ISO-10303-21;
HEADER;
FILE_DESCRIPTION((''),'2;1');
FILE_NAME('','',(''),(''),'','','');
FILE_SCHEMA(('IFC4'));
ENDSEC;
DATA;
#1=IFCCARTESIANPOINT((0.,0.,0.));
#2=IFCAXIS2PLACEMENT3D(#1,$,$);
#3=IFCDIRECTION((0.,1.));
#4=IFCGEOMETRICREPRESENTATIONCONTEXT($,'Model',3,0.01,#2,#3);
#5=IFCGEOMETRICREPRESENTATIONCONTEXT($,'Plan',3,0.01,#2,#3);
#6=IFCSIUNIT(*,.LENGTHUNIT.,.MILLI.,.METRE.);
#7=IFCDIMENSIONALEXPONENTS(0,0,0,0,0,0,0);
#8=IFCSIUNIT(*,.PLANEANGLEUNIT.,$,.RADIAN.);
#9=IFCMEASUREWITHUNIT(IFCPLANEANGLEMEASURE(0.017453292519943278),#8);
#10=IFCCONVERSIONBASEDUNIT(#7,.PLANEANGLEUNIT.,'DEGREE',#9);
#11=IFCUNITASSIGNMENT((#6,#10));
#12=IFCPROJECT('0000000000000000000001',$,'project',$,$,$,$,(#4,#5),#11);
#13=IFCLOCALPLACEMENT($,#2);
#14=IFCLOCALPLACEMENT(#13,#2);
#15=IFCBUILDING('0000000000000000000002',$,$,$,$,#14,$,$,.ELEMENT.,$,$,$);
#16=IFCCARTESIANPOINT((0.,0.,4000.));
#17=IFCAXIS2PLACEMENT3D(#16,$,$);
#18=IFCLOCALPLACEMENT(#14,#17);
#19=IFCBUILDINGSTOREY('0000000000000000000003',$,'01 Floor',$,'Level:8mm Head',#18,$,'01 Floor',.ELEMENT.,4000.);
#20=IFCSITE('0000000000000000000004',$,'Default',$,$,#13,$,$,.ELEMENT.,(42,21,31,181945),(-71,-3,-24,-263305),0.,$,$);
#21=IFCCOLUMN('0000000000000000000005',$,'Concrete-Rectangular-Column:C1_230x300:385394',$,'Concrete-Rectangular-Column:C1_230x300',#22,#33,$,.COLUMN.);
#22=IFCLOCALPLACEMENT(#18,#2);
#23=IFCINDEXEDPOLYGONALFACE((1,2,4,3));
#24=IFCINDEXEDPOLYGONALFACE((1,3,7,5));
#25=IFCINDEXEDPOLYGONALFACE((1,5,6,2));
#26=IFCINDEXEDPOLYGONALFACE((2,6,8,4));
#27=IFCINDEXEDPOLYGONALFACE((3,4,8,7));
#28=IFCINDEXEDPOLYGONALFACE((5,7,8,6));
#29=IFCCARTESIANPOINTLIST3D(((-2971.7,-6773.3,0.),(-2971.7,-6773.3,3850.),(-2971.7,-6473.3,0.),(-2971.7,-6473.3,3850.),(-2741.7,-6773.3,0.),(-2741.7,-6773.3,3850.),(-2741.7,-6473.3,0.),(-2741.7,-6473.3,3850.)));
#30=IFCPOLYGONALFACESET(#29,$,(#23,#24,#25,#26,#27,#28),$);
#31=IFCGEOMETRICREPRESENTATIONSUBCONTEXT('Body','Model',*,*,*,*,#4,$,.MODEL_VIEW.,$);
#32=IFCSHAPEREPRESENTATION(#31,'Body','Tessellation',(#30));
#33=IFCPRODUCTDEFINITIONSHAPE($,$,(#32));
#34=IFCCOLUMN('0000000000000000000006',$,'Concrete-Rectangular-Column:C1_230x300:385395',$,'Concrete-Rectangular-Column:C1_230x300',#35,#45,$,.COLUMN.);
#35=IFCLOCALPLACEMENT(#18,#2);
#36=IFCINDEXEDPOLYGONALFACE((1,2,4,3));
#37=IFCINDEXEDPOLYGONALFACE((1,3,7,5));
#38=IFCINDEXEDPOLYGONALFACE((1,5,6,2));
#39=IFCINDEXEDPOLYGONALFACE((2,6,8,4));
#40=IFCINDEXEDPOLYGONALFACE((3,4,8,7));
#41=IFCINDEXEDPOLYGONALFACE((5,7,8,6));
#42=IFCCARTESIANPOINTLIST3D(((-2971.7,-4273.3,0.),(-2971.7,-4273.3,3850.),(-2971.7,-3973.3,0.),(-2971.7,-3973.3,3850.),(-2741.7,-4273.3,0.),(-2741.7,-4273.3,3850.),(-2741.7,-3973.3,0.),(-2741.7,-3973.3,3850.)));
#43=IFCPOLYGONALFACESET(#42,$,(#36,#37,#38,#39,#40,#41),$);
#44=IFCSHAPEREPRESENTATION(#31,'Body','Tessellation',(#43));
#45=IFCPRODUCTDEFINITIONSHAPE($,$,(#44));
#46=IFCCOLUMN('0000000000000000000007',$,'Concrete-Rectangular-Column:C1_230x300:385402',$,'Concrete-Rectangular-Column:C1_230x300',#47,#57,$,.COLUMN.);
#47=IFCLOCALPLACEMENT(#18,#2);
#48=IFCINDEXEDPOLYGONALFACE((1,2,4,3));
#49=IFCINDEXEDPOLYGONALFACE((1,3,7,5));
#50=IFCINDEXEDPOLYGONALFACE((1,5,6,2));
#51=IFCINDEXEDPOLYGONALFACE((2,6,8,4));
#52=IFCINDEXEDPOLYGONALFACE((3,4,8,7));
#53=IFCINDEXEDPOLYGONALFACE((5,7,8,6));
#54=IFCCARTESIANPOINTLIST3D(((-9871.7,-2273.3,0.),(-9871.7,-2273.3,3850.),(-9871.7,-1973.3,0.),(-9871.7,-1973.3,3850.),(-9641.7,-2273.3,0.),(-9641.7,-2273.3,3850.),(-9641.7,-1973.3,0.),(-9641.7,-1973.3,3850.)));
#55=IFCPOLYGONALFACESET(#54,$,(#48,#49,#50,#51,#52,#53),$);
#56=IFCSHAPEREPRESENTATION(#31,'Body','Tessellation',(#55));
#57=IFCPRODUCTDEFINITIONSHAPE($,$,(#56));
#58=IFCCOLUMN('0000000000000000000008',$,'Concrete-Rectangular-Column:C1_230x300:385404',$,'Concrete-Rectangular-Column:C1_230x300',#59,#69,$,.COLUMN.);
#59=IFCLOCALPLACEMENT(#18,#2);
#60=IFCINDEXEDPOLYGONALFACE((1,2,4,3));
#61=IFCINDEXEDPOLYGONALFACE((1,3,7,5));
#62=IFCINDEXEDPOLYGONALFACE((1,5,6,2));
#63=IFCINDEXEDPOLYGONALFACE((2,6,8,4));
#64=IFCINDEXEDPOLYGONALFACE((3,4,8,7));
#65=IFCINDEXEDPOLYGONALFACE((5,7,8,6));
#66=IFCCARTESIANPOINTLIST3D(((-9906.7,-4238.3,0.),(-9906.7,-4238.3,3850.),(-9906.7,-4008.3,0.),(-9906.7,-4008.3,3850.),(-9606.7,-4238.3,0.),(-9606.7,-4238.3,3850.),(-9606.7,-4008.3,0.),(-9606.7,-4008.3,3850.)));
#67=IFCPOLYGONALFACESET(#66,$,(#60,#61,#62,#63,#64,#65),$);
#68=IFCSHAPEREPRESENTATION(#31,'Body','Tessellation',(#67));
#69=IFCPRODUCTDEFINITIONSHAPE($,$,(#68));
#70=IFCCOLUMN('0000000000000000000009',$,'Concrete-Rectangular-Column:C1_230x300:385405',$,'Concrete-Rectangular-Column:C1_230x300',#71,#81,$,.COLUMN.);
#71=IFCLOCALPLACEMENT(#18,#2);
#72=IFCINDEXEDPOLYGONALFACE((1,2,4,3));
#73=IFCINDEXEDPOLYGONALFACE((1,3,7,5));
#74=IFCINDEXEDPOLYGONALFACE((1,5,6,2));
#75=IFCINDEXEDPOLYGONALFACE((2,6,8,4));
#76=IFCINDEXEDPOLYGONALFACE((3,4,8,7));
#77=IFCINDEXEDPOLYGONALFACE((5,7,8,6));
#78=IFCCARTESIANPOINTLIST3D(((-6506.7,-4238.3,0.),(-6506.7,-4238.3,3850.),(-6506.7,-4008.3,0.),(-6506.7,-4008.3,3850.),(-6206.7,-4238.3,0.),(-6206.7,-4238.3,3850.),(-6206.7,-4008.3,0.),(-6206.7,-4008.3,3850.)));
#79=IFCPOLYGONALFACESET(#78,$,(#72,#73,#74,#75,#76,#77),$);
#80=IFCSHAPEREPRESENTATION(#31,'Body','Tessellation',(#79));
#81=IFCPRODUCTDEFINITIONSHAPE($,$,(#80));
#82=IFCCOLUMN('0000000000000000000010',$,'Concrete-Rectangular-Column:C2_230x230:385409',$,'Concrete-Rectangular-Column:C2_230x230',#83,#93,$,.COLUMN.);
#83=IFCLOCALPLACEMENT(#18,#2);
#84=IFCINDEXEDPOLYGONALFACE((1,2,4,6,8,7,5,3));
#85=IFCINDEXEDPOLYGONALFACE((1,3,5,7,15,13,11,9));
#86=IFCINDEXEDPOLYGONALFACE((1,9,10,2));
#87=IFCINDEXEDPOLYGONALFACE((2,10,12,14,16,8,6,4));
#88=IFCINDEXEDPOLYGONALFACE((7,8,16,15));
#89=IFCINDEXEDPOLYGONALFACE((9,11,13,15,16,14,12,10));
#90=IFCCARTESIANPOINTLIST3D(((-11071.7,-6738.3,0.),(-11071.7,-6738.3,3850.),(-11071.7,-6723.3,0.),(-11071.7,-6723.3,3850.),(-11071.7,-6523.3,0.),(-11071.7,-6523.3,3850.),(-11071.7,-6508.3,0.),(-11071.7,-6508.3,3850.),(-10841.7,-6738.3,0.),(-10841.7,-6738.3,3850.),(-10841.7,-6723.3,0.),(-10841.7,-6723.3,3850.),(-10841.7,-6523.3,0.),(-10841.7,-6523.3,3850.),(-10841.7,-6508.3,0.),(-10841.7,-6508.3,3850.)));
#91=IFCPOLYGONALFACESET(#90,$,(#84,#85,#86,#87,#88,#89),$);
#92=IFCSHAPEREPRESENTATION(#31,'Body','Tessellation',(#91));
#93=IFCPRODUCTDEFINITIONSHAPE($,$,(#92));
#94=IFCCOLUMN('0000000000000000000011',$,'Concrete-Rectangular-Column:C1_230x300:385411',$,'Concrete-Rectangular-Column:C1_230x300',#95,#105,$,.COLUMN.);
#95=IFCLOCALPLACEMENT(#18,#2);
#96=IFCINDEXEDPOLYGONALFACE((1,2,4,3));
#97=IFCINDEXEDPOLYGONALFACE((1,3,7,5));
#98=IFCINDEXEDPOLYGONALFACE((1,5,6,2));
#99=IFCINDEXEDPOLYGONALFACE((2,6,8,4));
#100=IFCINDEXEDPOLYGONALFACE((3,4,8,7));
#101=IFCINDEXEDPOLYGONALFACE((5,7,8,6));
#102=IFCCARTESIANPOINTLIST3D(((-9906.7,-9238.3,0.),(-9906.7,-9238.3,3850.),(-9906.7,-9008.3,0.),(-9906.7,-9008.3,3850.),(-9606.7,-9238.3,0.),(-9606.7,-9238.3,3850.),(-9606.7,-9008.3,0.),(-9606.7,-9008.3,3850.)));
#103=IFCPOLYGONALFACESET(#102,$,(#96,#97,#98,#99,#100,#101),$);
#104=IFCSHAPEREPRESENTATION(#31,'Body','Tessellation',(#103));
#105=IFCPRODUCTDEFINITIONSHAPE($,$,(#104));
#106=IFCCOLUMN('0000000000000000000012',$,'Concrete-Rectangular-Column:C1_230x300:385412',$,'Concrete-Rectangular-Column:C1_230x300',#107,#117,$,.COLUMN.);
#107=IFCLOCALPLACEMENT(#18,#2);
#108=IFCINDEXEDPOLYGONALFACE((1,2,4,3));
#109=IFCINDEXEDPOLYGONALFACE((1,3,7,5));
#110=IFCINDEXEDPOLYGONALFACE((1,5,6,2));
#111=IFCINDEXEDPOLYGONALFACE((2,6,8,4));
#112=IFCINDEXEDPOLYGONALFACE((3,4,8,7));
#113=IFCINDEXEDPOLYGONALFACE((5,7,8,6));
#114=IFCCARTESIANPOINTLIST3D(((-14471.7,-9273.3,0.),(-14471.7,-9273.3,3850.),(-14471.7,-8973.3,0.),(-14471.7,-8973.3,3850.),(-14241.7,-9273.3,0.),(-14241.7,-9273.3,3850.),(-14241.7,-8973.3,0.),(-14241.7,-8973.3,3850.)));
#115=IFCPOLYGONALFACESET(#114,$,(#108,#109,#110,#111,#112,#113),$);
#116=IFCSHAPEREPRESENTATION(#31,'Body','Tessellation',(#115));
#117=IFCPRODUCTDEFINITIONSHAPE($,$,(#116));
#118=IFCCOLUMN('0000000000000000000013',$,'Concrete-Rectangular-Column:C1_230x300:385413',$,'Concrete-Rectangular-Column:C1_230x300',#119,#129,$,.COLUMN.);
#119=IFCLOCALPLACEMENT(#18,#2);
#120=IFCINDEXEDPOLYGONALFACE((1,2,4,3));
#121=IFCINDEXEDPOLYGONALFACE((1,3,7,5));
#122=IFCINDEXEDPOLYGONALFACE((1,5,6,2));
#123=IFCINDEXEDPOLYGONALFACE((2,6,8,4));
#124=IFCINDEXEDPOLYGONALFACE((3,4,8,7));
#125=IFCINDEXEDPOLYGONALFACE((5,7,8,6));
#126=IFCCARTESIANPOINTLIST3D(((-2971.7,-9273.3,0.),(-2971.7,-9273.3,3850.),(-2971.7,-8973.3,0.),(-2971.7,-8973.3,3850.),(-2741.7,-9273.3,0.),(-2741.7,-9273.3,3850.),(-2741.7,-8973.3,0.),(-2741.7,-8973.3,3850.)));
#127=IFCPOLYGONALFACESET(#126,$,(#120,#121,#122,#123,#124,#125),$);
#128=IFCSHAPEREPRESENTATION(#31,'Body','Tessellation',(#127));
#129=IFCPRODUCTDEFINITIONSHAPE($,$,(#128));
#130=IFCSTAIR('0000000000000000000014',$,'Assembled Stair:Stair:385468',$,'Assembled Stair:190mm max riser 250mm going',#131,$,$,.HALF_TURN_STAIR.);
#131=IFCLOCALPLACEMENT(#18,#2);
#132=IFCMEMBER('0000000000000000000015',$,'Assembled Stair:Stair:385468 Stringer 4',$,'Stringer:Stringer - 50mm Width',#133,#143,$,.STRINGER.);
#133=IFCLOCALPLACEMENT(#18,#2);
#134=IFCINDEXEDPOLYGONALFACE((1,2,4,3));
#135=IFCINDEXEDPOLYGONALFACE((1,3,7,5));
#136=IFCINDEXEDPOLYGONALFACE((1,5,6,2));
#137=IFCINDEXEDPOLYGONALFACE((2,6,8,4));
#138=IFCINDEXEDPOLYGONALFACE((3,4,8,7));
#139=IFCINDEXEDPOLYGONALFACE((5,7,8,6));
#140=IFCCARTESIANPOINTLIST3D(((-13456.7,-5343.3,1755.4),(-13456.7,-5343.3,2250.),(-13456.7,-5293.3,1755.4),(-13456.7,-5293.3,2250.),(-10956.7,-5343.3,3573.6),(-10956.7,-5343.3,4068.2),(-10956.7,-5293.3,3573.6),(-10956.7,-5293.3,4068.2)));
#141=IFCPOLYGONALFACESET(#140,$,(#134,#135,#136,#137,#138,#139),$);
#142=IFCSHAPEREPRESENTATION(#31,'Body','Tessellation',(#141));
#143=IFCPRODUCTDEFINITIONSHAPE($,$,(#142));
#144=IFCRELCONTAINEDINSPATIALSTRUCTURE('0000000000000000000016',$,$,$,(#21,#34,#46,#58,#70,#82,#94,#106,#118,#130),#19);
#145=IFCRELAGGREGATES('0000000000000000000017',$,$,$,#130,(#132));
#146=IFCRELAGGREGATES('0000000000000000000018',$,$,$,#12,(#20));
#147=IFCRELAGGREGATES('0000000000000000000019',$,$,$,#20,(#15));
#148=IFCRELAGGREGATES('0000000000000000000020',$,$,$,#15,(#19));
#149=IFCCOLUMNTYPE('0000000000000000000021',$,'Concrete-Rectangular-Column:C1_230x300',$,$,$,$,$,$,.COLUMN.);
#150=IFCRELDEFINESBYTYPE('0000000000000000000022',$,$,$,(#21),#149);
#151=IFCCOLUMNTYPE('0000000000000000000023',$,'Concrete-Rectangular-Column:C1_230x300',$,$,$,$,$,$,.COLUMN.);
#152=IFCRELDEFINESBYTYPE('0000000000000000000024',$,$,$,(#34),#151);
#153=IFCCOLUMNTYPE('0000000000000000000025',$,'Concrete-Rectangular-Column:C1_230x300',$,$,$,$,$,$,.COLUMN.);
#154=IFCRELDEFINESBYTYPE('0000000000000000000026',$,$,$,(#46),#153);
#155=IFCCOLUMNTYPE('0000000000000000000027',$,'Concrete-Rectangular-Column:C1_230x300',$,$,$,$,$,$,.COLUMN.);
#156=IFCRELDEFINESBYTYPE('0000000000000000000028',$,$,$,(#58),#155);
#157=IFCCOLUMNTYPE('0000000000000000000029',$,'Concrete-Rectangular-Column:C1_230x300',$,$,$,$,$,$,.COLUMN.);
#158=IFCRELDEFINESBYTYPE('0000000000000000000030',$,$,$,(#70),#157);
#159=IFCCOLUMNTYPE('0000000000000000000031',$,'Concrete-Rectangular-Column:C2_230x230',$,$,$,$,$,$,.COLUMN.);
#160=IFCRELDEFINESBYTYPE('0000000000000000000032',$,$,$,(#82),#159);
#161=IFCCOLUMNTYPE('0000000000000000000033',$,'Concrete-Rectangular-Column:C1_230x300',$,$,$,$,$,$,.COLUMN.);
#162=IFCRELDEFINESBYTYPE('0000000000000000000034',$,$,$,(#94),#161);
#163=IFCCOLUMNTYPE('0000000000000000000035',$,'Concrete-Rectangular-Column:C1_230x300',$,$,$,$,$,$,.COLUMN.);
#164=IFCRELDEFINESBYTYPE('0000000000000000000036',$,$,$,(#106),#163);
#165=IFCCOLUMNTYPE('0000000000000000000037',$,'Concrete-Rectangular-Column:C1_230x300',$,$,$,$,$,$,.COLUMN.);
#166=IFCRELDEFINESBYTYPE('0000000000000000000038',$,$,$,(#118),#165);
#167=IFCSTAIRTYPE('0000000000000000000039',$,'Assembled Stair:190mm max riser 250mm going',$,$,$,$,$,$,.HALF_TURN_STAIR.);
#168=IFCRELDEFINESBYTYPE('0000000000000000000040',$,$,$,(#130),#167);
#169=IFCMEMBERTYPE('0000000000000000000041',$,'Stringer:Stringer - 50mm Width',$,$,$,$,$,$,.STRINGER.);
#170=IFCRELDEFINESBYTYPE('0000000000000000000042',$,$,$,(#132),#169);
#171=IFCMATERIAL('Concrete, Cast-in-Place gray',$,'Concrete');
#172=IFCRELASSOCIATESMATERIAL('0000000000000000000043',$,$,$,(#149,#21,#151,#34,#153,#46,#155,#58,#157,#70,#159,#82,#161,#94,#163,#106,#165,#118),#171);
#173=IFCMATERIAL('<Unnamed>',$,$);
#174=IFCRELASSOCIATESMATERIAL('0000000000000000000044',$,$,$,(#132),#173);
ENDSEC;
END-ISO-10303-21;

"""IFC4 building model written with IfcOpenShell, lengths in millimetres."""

from ifc_helpers import new_model, entity, si_unit, converted_unit, direction, frame, origin, place, context, subcontext, project, spatial, indexed_curve, outline, extrude, source, transform, mapped, material, type_object, type_shapes, element, aggregate, save


model = new_model("IFC4")

# Units and contexts
model_context = context("Model", 3, precision=0.01, world=origin(), true_north=direction((0.0, 1.0)))
plan_context = context("Plan", 3, precision=0.01, world=origin(), true_north=direction((0.0, 1.0)))
body_context = subcontext(model_context, "Body", "Model", "MODEL_VIEW")
ifc_project = project(units=[si_unit("LENGTHUNIT", "METRE", prefix="MILLI"), converted_unit("PLANEANGLEUNIT", "DEGREE", entity("IfcPlaneAngleMeasure", 0.017453292519943278), si_unit("PLANEANGLEUNIT", "RADIAN"), dimensions=[0, 0, 0, 0, 0, 0, 0])], contexts=[model_context, plan_context])

# Site, building, storey
site_placement = place(None, origin())
site = spatial("IfcSite", under=ifc_project, at=site_placement, Name="Default", CompositionType="ELEMENT", RefLatitude=(42, 21, 31, 181945), RefLongitude=(-71, -3, -24, -263305), RefElevation=0.0)
building_placement = place(site_placement, origin())
building = spatial("IfcBuilding", under=site, at=building_placement, CompositionType="ELEMENT")
storey_placement = place(building_placement, frame((0.0, 0.0, 4000.0)))
storey = spatial("IfcBuildingStorey", under=building, at=storey_placement, Name="01 Floor", ObjectType="Level:8mm Head", LongName="01 Floor", CompositionType="ELEMENT", Elevation=4000.0)

# Columns
ifc_material_1 = material(Name="Concrete, Cast-in-Place gray", Category="Concrete")
column_type_1 = type_object("IfcColumnType", Name="Concrete-Rectangular-Column:C1_230x300", PredefinedType="COLUMN", material=ifc_material_1)
shared_shape_1 = source(origin(), body_context, "Body", "SweptSolid", [
    extrude(outline(indexed_curve([(-115.0, -150.0), (115.0, -150.0), (115.0, 150.0), (-115.0, 150.0), (-115.0, -150.0)], self_intersect=False)), frame((-2856.7, -6623.3, 4000.0), z_axis=(0.0, 0.0, 1.0), x_axis=(-1.0, 0.0, 0.0)), (0.0, 0.0, 1.0), 3850.0),
])
type_shapes(column_type_1, [shared_shape_1])
column_1_placement = place(storey_placement, frame((0.0, 0.0, -4000.0)))
element("IfcColumn", 1, at=column_1_placement, inside=storey, type_object=column_type_1, material=ifc_material_1, Name="Concrete-Rectangular-Column:C1_230x300:385394", ObjectType="Concrete-Rectangular-Column:C1_230x300", PredefinedType="COLUMN", context=body_context, shape_type="MappedRepresentation", body=[
    mapped(shared_shape_1, transform((0.0, 0.0, 0.0), scale=1.0)),
])
column_type_2 = type_object("IfcColumnType", Name="Concrete-Rectangular-Column:C1_230x300", PredefinedType="COLUMN", material=ifc_material_1)
shared_shape_2 = source(origin(), body_context, "Body", "SweptSolid", [
    extrude(outline(indexed_curve([(-115.0, -150.0), (115.0, -150.0), (115.0, 150.0), (-115.0, 150.0), (-115.0, -150.0)], self_intersect=False)), frame((-2856.7, -4123.3, 4000.0)), (0.0, 0.0, 1.0), 3850.0),
])
type_shapes(column_type_2, [shared_shape_2])
column_2_placement = place(storey_placement, frame((0.0, 0.0, -4000.0)))
element("IfcColumn", 2, at=column_2_placement, inside=storey, type_object=column_type_2, material=ifc_material_1, Name="Concrete-Rectangular-Column:C1_230x300:385395", ObjectType="Concrete-Rectangular-Column:C1_230x300", PredefinedType="COLUMN", context=body_context, shape_type="MappedRepresentation", body=[
    mapped(shared_shape_2, transform((0.0, 0.0, 0.0), scale=1.0)),
])
column_type_3 = type_object("IfcColumnType", Name="Concrete-Rectangular-Column:C1_230x300", PredefinedType="COLUMN", material=ifc_material_1)
shared_shape_3 = source(origin(), body_context, "Body", "SweptSolid", [
    extrude(outline(indexed_curve([(-115.0, -150.0), (115.0, -150.0), (115.0, 150.0), (-115.0, 150.0), (-115.0, -150.0)], self_intersect=False)), frame((-9756.7, -2123.3, 4000.0)), (0.0, 0.0, 1.0), 3850.0),
])
type_shapes(column_type_3, [shared_shape_3])
column_3_placement = place(storey_placement, frame((0.0, 0.0, -4000.0)))
element("IfcColumn", 3, at=column_3_placement, inside=storey, type_object=column_type_3, material=ifc_material_1, Name="Concrete-Rectangular-Column:C1_230x300:385402", ObjectType="Concrete-Rectangular-Column:C1_230x300", PredefinedType="COLUMN", context=body_context, shape_type="MappedRepresentation", body=[
    mapped(shared_shape_3, transform((0.0, 0.0, 0.0), scale=1.0)),
])
column_type_4 = type_object("IfcColumnType", Name="Concrete-Rectangular-Column:C1_230x300", PredefinedType="COLUMN", material=ifc_material_1)
shared_shape_4 = source(origin(), body_context, "Body", "SweptSolid", [
    extrude(outline(indexed_curve([(-1925.0, -115.0), (1925.0, -115.0), (1925.0, 115.0), (-1925.0, 115.0), (-1925.0, -115.0)], self_intersect=False)), frame((-9906.7, -4123.3, 5925.0), z_axis=(1.0, 0.0, 0.0), x_axis=(0.0, 0.0, 1.0)), (0.0, 0.0, 1.0), 300.0),
])
type_shapes(column_type_4, [shared_shape_4])
column_4_placement = place(storey_placement, frame((0.0, 0.0, -4000.0)))
element("IfcColumn", 4, at=column_4_placement, inside=storey, type_object=column_type_4, material=ifc_material_1, Name="Concrete-Rectangular-Column:C1_230x300:385404", ObjectType="Concrete-Rectangular-Column:C1_230x300", PredefinedType="COLUMN", context=body_context, shape_type="MappedRepresentation", body=[
    mapped(shared_shape_4, transform((0.0, 0.0, 0.0), scale=1.0)),
])
column_type_5 = type_object("IfcColumnType", Name="Concrete-Rectangular-Column:C1_230x300", PredefinedType="COLUMN", material=ifc_material_1)
shared_shape_5 = source(origin(), body_context, "Body", "SweptSolid", [
    extrude(outline(indexed_curve([(-1925.0, -115.0), (1925.0, -115.0), (1925.0, 115.0), (-1925.0, 115.0), (-1925.0, -115.0)], self_intersect=False)), frame((-6506.7, -4123.3, 5925.0), z_axis=(1.0, 0.0, 0.0), x_axis=(0.0, 0.0, 1.0)), (0.0, 0.0, 1.0), 300.0),
])
type_shapes(column_type_5, [shared_shape_5])
column_5_placement = place(storey_placement, frame((0.0, 0.0, -4000.0)))
element("IfcColumn", 5, at=column_5_placement, inside=storey, type_object=column_type_5, material=ifc_material_1, Name="Concrete-Rectangular-Column:C1_230x300:385405", ObjectType="Concrete-Rectangular-Column:C1_230x300", PredefinedType="COLUMN", context=body_context, shape_type="MappedRepresentation", body=[
    mapped(shared_shape_5, transform((0.0, 0.0, 0.0), scale=1.0)),
])
column_type_6 = type_object("IfcColumnType", Name="Concrete-Rectangular-Column:C2_230x230", PredefinedType="COLUMN", material=ifc_material_1)
shared_shape_6 = source(origin(), body_context, "Body", "SweptSolid", [
    extrude(outline(indexed_curve([(-115.0, -115.0), (-100.0, -115.0), (100.0, -115.0), (115.0, -115.0), (115.0, 115.0), (100.0, 115.0), (-100.0, 115.0), (-115.0, 115.0), (-115.0, -115.0)], self_intersect=False)), frame((-10956.7, -6623.3, 4000.0), z_axis=(0.0, 0.0, 1.0), x_axis=(0.0, -1.0, 0.0)), (0.0, 0.0, 1.0), 3850.0),
])
type_shapes(column_type_6, [shared_shape_6])
column_6_placement = place(storey_placement, frame((0.0, 0.0, -4000.0)))
element("IfcColumn", 6, at=column_6_placement, inside=storey, type_object=column_type_6, material=ifc_material_1, Name="Concrete-Rectangular-Column:C2_230x230:385409", ObjectType="Concrete-Rectangular-Column:C2_230x230", PredefinedType="COLUMN", context=body_context, shape_type="MappedRepresentation", body=[
    mapped(shared_shape_6, transform((0.0, 0.0, 0.0), scale=1.0)),
])
column_type_7 = type_object("IfcColumnType", Name="Concrete-Rectangular-Column:C1_230x300", PredefinedType="COLUMN", material=ifc_material_1)
shared_shape_7 = source(origin(), body_context, "Body", "SweptSolid", [
    extrude(outline(indexed_curve([(-1925.0, -115.0), (1925.0, -115.0), (1925.0, 115.0), (-1925.0, 115.0), (-1925.0, -115.0)], self_intersect=False)), frame((-9906.7, -9123.3, 5925.0), z_axis=(1.0, 0.0, 0.0), x_axis=(0.0, 0.0, 1.0)), (0.0, 0.0, 1.0), 300.0),
])
type_shapes(column_type_7, [shared_shape_7])
column_7_placement = place(storey_placement, frame((0.0, 0.0, -4000.0)))
element("IfcColumn", 7, at=column_7_placement, inside=storey, type_object=column_type_7, material=ifc_material_1, Name="Concrete-Rectangular-Column:C1_230x300:385411", ObjectType="Concrete-Rectangular-Column:C1_230x300", PredefinedType="COLUMN", context=body_context, shape_type="MappedRepresentation", body=[
    mapped(shared_shape_7, transform((0.0, 0.0, 0.0), scale=1.0)),
])
column_type_8 = type_object("IfcColumnType", Name="Concrete-Rectangular-Column:C1_230x300", PredefinedType="COLUMN", material=ifc_material_1)
shared_shape_8 = source(origin(), body_context, "Body", "SweptSolid", [
    extrude(outline(indexed_curve([(-115.0, -150.0), (115.0, -150.0), (115.0, 150.0), (-115.0, 150.0), (-115.0, -150.0)], self_intersect=False)), frame((-14356.7, -9123.3, 4000.0), z_axis=(0.0, 0.0, 1.0), x_axis=(-1.0, 0.0, 0.0)), (0.0, 0.0, 1.0), 3850.0),
])
type_shapes(column_type_8, [shared_shape_8])
column_8_placement = place(storey_placement, frame((0.0, 0.0, -4000.0)))
element("IfcColumn", 8, at=column_8_placement, inside=storey, type_object=column_type_8, material=ifc_material_1, Name="Concrete-Rectangular-Column:C1_230x300:385412", ObjectType="Concrete-Rectangular-Column:C1_230x300", PredefinedType="COLUMN", context=body_context, shape_type="MappedRepresentation", body=[
    mapped(shared_shape_8, transform((0.0, 0.0, 0.0), scale=1.0)),
])
column_type_9 = type_object("IfcColumnType", Name="Concrete-Rectangular-Column:C1_230x300", PredefinedType="COLUMN", material=ifc_material_1)
shared_shape_9 = source(origin(), body_context, "Body", "SweptSolid", [
    extrude(outline(indexed_curve([(-115.0, -150.0), (115.0, -150.0), (115.0, 150.0), (-115.0, 150.0), (-115.0, -150.0)], self_intersect=False)), frame((-2856.7, -9123.3, 4000.0), z_axis=(0.0, 0.0, 1.0), x_axis=(-1.0, 0.0, 0.0)), (0.0, 0.0, 1.0), 3850.0),
])
type_shapes(column_type_9, [shared_shape_9])
column_9_placement = place(storey_placement, frame((0.0, 0.0, -4000.0)))
element("IfcColumn", 9, at=column_9_placement, inside=storey, type_object=column_type_9, material=ifc_material_1, Name="Concrete-Rectangular-Column:C1_230x300:385413", ObjectType="Concrete-Rectangular-Column:C1_230x300", PredefinedType="COLUMN", context=body_context, shape_type="MappedRepresentation", body=[
    mapped(shared_shape_9, transform((0.0, 0.0, 0.0), scale=1.0)),
])

# Stair, member
stair_type = type_object("IfcStairType", Name="Assembled Stair:190mm max riser 250mm going", PredefinedType="HALF_TURN_STAIR")
stair_placement = place(storey_placement, origin())
stair = element("IfcStair", 10, at=stair_placement, inside=storey, type_object=stair_type, Name="Assembled Stair:Stair:385468", ObjectType="Assembled Stair:190mm max riser 250mm going", PredefinedType="HALF_TURN_STAIR")
ifc_material_2 = material(Name="<Unnamed>")
member_type = type_object("IfcMemberType", Name="Stringer:Stringer - 50mm Width", PredefinedType="STRINGER")
member_1_placement = place(stair_placement, origin())
member_1 = element("IfcMember", 11, at=member_1_placement, type_object=member_type, material=ifc_material_2, Name="Assembled Stair:Stair:385468 Stringer 4", ObjectType="Stringer:Stringer - 50mm Width", PredefinedType="STRINGER", context=body_context, shape_type="SweptSolid", body=[
    extrude(outline(indexed_curve([(-1400.2, -200.0), (1691.1, -200.0), (1400.2, 200.0), (-1691.1, 200.0), (-1400.2, -200.0)], self_intersect=False)), frame((-12206.7, -5343.3, 2911.8), z_axis=(0.0, 1.0, 0.0), x_axis=(0.808736, 0.0, 0.588172)), (0.0, 0.0, 1.0), 50.0),
])

aggregate(stair, [member_1])

save(model, "model.ifc")
